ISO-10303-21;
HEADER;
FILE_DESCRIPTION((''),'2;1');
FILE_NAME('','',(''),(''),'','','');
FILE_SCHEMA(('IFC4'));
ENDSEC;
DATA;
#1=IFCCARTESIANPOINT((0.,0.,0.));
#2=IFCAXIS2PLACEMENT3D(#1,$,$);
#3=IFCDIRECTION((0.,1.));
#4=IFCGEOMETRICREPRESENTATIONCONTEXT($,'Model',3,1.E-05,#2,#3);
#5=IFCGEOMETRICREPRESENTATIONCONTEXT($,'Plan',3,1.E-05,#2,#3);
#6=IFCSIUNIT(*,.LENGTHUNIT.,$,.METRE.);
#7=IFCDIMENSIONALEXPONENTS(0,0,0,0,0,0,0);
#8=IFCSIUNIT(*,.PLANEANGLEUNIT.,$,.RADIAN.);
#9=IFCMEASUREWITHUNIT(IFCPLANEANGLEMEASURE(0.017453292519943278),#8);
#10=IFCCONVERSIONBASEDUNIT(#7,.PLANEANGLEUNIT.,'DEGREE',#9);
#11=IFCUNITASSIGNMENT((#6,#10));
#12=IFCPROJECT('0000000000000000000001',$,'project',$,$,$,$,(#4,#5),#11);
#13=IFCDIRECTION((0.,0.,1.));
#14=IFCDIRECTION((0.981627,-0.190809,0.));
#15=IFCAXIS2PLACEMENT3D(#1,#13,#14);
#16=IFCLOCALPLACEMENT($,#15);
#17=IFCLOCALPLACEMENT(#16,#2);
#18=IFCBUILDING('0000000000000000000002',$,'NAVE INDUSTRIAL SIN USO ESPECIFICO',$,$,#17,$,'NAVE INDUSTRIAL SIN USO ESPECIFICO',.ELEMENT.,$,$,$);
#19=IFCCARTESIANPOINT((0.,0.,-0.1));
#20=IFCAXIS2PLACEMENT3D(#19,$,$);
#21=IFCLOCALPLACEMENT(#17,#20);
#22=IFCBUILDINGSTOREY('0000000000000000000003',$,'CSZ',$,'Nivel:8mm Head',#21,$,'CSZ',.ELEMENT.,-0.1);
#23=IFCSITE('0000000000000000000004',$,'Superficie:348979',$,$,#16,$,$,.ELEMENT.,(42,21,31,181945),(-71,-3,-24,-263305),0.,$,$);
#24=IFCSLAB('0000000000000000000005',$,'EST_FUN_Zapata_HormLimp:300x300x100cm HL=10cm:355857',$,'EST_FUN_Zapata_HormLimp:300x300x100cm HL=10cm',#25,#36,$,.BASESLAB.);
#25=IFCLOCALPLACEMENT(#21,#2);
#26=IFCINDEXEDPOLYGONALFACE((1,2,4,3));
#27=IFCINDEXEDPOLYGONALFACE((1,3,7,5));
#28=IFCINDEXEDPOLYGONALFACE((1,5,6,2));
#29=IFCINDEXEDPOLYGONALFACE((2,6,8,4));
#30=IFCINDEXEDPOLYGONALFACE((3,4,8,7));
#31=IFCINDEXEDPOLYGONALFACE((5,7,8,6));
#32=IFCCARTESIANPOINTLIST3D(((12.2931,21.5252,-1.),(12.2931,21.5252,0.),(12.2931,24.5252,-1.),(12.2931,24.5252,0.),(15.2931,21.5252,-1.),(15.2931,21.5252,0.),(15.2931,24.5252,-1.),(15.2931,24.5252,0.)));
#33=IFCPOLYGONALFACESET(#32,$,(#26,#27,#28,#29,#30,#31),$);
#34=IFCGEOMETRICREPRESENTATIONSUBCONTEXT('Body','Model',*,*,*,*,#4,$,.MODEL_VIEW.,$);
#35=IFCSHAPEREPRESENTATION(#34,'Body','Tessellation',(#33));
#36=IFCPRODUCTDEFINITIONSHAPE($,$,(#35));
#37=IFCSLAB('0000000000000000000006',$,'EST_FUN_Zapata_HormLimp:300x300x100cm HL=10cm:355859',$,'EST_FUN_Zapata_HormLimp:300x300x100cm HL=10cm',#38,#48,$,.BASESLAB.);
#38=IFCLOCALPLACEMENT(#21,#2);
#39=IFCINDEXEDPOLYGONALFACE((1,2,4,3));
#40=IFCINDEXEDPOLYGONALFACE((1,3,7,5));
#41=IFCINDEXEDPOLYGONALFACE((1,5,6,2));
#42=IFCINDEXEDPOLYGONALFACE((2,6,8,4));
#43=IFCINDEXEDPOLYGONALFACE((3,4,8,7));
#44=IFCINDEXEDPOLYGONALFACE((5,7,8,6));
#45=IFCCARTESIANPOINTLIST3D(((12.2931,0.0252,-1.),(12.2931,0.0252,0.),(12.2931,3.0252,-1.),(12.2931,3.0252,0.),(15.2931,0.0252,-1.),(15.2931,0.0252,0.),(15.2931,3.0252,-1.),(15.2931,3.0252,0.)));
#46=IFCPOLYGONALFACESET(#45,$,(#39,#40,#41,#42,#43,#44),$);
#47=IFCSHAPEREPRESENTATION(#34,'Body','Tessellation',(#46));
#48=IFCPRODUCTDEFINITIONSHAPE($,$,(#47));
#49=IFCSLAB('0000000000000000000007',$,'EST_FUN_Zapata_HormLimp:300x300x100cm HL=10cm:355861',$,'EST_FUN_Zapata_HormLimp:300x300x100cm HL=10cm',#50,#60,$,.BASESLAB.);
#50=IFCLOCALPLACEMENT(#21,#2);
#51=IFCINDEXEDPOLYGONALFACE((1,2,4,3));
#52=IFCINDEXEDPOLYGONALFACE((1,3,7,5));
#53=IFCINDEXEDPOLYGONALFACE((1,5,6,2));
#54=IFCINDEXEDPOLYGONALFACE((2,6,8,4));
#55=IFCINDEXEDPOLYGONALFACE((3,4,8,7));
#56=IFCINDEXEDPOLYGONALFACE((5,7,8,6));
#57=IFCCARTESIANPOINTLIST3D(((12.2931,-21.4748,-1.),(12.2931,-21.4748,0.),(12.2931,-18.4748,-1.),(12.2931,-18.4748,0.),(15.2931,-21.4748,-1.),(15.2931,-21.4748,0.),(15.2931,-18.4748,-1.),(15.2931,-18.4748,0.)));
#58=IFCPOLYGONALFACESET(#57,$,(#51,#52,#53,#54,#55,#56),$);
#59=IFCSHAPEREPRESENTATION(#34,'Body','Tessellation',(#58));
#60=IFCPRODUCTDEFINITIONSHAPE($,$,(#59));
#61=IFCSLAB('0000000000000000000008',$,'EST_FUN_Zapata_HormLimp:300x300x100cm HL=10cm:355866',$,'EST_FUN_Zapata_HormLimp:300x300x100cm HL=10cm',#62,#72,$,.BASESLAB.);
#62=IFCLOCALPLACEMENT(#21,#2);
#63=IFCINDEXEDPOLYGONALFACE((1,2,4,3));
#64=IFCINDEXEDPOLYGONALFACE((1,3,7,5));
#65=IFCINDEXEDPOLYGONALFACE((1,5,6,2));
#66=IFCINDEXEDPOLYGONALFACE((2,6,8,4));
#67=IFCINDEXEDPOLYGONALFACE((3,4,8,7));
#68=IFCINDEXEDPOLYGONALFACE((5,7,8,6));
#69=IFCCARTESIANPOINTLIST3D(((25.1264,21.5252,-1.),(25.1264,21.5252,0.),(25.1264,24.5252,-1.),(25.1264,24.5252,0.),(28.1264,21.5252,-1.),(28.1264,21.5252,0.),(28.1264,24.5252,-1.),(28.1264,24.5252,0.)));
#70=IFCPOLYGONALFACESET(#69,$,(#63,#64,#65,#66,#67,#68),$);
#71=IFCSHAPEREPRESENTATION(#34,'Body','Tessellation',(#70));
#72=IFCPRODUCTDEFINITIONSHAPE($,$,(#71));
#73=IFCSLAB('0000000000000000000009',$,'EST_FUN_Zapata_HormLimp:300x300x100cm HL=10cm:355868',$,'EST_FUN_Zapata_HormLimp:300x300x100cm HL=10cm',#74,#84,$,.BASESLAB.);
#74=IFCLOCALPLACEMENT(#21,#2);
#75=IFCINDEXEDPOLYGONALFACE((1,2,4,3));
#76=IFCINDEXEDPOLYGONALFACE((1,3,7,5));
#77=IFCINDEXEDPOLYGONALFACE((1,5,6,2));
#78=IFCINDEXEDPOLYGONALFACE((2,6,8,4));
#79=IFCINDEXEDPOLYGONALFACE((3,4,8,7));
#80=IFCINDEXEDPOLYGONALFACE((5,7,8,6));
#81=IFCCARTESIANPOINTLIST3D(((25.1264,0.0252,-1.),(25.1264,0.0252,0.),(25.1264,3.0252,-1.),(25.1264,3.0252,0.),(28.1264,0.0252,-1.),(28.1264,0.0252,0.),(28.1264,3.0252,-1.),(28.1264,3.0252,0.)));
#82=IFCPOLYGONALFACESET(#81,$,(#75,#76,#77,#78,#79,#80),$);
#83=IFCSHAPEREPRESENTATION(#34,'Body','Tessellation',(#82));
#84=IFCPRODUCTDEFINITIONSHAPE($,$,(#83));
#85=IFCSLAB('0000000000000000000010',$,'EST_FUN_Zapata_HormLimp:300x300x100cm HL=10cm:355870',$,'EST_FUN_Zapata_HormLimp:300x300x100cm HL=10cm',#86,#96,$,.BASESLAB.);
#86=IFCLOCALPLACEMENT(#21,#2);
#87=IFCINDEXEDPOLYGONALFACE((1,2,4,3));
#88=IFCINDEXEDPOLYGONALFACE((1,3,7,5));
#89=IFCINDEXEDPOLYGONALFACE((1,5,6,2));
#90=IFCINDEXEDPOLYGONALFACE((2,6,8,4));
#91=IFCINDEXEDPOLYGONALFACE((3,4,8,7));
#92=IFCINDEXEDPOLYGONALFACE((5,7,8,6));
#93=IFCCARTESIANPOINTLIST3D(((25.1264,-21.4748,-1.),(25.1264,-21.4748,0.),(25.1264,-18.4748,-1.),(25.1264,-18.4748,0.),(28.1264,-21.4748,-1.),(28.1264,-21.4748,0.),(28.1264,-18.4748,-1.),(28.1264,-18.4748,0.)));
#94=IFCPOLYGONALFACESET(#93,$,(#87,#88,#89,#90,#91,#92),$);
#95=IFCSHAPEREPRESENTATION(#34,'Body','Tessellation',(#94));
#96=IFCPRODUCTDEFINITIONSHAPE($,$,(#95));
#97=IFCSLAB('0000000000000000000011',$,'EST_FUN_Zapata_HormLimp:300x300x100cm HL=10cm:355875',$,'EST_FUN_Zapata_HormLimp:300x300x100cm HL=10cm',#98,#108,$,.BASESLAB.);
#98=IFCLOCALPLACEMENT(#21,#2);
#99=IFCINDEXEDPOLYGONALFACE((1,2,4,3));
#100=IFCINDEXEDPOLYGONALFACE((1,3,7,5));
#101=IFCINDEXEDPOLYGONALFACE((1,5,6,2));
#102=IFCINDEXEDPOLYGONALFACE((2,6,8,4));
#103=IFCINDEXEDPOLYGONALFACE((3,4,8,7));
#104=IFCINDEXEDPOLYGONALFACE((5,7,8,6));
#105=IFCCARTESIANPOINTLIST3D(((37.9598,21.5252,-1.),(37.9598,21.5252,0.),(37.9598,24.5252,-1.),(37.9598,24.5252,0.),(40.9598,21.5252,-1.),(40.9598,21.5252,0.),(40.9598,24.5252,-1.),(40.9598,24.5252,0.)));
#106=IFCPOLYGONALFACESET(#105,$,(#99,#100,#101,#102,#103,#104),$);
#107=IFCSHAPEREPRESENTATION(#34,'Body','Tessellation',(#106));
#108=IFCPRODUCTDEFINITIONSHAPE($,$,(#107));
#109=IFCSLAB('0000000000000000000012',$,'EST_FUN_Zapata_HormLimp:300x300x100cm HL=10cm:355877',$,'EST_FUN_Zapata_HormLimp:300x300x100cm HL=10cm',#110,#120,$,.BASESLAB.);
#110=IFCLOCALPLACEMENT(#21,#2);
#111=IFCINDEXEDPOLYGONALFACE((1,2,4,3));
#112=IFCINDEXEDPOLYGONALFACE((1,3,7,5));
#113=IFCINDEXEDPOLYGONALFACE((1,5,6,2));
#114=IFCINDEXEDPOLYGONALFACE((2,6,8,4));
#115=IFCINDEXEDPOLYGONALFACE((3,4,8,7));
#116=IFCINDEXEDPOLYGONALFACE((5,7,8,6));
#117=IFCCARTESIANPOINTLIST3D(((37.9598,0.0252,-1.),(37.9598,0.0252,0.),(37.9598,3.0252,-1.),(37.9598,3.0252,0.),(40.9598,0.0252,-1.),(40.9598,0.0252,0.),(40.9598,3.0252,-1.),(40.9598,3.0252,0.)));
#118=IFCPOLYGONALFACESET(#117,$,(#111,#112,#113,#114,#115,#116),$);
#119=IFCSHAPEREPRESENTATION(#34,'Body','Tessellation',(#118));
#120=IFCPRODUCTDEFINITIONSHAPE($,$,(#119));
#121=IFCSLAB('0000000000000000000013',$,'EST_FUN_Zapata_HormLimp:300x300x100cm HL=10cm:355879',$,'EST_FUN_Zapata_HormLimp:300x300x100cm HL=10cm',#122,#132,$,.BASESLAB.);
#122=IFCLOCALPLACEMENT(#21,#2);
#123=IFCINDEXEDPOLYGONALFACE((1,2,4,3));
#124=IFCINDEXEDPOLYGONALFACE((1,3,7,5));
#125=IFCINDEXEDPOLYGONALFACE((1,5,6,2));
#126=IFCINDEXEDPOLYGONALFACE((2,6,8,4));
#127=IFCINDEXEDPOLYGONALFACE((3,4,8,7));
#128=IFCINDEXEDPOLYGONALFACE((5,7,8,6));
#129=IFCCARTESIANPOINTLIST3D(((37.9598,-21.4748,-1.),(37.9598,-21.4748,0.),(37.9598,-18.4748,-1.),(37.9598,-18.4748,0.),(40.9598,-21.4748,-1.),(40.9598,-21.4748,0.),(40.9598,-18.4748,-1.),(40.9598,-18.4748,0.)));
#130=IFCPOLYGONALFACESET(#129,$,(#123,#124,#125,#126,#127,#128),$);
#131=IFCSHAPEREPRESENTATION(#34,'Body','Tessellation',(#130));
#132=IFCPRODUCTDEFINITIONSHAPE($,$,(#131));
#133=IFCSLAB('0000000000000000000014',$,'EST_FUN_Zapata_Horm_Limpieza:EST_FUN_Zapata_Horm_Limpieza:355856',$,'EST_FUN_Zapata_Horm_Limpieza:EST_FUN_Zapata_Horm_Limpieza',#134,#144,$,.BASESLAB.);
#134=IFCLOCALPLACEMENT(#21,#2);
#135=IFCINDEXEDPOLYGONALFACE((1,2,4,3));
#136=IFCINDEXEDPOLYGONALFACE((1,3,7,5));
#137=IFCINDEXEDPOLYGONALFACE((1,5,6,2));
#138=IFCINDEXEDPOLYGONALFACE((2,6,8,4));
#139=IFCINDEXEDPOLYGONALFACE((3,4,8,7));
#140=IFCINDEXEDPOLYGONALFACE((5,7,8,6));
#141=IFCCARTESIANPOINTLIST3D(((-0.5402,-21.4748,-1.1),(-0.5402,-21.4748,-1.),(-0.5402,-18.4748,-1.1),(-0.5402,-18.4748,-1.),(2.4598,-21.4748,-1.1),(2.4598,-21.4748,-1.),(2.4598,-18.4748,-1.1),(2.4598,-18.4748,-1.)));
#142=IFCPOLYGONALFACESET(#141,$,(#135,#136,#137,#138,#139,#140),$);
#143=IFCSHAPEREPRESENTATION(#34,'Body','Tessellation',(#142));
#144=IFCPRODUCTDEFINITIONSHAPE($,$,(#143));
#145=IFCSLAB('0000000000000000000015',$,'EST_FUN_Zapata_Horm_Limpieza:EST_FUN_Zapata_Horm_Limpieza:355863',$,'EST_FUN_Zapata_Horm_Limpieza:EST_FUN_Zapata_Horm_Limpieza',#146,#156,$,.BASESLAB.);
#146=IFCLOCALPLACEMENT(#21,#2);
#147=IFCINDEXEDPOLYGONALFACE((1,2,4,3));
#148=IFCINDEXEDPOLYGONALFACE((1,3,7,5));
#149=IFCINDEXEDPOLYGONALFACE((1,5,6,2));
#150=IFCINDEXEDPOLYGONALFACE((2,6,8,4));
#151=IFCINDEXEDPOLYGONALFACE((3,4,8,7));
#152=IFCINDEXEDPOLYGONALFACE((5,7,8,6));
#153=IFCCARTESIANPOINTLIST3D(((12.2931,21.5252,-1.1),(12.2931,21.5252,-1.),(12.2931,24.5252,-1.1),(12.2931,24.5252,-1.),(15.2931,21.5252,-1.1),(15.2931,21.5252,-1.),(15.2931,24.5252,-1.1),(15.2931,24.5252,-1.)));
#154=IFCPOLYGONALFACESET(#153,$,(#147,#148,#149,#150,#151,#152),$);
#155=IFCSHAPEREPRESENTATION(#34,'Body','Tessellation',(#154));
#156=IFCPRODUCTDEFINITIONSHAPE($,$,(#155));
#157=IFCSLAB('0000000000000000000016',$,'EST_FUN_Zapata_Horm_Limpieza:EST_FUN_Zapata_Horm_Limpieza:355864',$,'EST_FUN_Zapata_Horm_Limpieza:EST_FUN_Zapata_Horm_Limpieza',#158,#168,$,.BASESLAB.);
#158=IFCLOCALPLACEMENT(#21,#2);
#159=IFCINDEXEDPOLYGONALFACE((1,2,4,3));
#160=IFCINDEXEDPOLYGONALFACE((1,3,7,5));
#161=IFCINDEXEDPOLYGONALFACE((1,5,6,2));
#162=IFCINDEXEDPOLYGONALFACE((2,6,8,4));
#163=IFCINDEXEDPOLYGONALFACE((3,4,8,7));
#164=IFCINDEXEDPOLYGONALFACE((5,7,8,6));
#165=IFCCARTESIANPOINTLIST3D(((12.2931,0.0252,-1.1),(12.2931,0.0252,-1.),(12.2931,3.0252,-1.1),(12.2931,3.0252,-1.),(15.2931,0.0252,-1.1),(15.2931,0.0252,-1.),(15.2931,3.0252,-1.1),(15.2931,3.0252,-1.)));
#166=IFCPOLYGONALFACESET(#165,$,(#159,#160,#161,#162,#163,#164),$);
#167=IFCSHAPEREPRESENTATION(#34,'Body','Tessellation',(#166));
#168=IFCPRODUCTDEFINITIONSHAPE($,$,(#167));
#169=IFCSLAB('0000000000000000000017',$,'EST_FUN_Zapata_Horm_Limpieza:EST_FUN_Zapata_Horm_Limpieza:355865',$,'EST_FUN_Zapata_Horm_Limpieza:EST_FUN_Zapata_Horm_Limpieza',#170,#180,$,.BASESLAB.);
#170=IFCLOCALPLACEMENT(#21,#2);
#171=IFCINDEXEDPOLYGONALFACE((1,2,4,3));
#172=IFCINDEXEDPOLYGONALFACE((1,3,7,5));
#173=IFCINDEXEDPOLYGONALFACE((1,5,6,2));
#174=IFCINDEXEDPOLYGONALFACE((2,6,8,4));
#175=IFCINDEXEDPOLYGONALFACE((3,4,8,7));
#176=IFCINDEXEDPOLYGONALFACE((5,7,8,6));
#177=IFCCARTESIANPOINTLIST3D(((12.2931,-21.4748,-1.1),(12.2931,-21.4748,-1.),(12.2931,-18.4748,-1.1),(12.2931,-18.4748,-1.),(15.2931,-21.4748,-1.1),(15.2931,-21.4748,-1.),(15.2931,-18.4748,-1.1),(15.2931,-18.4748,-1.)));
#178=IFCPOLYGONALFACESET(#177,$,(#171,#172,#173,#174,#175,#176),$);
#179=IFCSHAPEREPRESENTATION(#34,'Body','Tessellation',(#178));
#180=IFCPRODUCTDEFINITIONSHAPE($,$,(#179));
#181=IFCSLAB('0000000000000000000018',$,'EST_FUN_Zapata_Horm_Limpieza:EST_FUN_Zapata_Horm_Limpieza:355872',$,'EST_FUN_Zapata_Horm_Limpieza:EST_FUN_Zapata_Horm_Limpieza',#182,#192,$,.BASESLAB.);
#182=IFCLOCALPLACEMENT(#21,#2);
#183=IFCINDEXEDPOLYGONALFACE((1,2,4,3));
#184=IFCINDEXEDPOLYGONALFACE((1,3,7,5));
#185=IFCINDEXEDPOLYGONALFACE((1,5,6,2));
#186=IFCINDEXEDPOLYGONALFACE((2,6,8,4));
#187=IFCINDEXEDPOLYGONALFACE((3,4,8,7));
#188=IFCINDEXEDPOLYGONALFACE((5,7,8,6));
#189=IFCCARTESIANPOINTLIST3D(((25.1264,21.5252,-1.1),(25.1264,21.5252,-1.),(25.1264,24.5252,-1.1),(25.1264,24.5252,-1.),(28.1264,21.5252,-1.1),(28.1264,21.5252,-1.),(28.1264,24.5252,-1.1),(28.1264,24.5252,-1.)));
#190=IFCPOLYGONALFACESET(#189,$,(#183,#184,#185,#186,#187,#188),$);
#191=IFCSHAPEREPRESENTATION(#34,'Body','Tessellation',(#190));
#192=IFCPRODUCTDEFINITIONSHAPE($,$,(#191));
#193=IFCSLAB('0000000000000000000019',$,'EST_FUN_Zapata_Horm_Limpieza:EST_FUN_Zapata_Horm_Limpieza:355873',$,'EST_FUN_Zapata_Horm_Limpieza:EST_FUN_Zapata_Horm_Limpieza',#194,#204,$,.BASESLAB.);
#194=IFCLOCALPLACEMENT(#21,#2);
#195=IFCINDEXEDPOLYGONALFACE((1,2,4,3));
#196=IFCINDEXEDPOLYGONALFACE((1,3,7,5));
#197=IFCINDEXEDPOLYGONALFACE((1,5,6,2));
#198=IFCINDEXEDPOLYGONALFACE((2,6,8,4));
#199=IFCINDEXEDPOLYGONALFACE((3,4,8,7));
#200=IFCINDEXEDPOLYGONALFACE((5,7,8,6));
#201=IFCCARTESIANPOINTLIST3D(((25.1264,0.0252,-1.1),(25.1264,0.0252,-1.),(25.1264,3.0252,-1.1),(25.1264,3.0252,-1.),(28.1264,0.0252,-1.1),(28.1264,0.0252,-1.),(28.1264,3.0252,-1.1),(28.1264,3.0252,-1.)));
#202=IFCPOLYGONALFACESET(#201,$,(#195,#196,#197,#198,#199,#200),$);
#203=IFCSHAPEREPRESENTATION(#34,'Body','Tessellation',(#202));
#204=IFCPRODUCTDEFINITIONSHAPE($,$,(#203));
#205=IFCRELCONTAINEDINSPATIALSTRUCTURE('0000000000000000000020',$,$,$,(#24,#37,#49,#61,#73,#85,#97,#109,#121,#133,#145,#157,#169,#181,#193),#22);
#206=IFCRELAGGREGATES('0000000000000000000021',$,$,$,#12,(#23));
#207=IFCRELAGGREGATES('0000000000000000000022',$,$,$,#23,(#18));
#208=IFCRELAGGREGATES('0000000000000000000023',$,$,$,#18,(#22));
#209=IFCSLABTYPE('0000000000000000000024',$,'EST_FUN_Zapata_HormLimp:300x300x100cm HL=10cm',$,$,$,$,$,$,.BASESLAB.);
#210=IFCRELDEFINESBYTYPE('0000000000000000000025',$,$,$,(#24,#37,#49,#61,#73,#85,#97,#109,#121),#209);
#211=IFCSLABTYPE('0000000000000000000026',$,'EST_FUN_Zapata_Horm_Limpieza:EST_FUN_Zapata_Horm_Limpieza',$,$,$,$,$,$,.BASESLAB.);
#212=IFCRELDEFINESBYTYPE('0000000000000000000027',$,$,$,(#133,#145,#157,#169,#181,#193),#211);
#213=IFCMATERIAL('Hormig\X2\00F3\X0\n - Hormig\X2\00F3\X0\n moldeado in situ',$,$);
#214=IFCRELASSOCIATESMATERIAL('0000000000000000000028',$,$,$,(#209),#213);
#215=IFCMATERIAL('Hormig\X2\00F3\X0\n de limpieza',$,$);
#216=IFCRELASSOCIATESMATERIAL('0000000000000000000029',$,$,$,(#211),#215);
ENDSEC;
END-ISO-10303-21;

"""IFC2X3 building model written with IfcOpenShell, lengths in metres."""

from ifc_helpers import new_model, entity, si_unit, converted_unit, direction, frame, frame_2d, origin, origin_2d_with_axis, place, context, subcontext, project, spatial, rectangle, extrude, material, type_object, element, save


model = new_model("IFC2X3")

# Units and contexts
model_context = context("Model", 3, precision=1e-05, world=origin(), true_north=direction((0.0, 1.0)))
plan_context = context("Plan", 3, precision=1e-05, world=origin(), true_north=direction((0.0, 1.0)))
body_context = subcontext(model_context, "Body", "Model", "MODEL_VIEW")
ifc_project = project(units=[si_unit("LENGTHUNIT", "METRE"), converted_unit("PLANEANGLEUNIT", "DEGREE", entity("IfcPlaneAngleMeasure", 0.017453292519943278), si_unit("PLANEANGLEUNIT", "RADIAN"), dimensions=[0, 0, 0, 0, 0, 0, 0])], contexts=[model_context, plan_context])

# Site, building, storey
site_placement = place(None, frame((0.0, 0.0, 0.0), z_axis=(0.0, 0.0, 1.0), x_axis=(0.981627, -0.190809, 0.0)))
site = spatial("IfcSite", under=ifc_project, at=site_placement, Name="Superficie:348979", CompositionType="ELEMENT", RefLatitude=(42, 21, 31, 181945), RefLongitude=(-71, -3, -24, -263305), RefElevation=0.0)
building_placement = place(site_placement, origin())
building = spatial("IfcBuilding", under=site, at=building_placement, Name="NAVE INDUSTRIAL SIN USO ESPECIFICO", LongName="NAVE INDUSTRIAL SIN USO ESPECIFICO", CompositionType="ELEMENT")
storey_placement = place(building_placement, frame((0.0, 0.0, -0.1)))
storey = spatial("IfcBuildingStorey", under=building, at=storey_placement, Name="CSZ", ObjectType="Nivel:8mm Head", LongName="CSZ", CompositionType="ELEMENT", Elevation=-0.1)

# Slabs
ifc_material_1 = material(Name="Hormigón - Hormigón moldeado in situ")
slab_type_1 = type_object("IfcSlabType", Name="EST_FUN_Zapata_HormLimp:300x300x100cm HL=10cm", PredefinedType="BASESLAB", material=ifc_material_1)
slab_1_placement = place(storey_placement, origin())
element("IfcSlab", 1, at=slab_1_placement, inside=storey, type_object=slab_type_1, Name="EST_FUN_Zapata_HormLimp:300x300x100cm HL=10cm:355857", ObjectType="EST_FUN_Zapata_HormLimp:300x300x100cm HL=10cm", PredefinedType="BASESLAB", context=body_context, shape_type="SweptSolid", body=[
    extrude(rectangle(XDim=3.0, YDim=3.0, at=frame_2d((0.0, 0.0), x_axis=(1.0, 0.0))), frame((13.7931, 23.0252, -1.0)), (0.0, 0.0, 1.0), 1.0),
])
slab_2_placement = place(storey_placement, origin())
element("IfcSlab", 2, at=slab_2_placement, inside=storey, type_object=slab_type_1, Name="EST_FUN_Zapata_HormLimp:300x300x100cm HL=10cm:355859", ObjectType="EST_FUN_Zapata_HormLimp:300x300x100cm HL=10cm", PredefinedType="BASESLAB", context=body_context, shape_type="SweptSolid", body=[
    extrude(rectangle(XDim=3.0, YDim=3.0, at=frame_2d((0.0, 0.0), x_axis=(1.0, 0.0))), frame((13.7931, 1.5252, -1.0)), (0.0, 0.0, 1.0), 1.0),
])
slab_3_placement = place(storey_placement, origin())
element("IfcSlab", 3, at=slab_3_placement, inside=storey, type_object=slab_type_1, Name="EST_FUN_Zapata_HormLimp:300x300x100cm HL=10cm:355861", ObjectType="EST_FUN_Zapata_HormLimp:300x300x100cm HL=10cm", PredefinedType="BASESLAB", context=body_context, shape_type="SweptSolid", body=[
    extrude(rectangle(XDim=3.0, YDim=3.0, at=frame_2d((0.0, 0.0), x_axis=(1.0, 0.0))), frame((13.7931, -19.9748, -1.0)), (0.0, 0.0, 1.0), 1.0),
])
slab_4_placement = place(storey_placement, origin())
element("IfcSlab", 4, at=slab_4_placement, inside=storey, type_object=slab_type_1, Name="EST_FUN_Zapata_HormLimp:300x300x100cm HL=10cm:355866", ObjectType="EST_FUN_Zapata_HormLimp:300x300x100cm HL=10cm", PredefinedType="BASESLAB", context=body_context, shape_type="SweptSolid", body=[
    extrude(rectangle(XDim=3.0, YDim=3.0, at=frame_2d((0.0, 0.0), x_axis=(1.0, 0.0))), frame((26.6264, 23.0252, -1.0)), (0.0, 0.0, 1.0), 1.0),
])
slab_5_placement = place(storey_placement, origin())
element("IfcSlab", 5, at=slab_5_placement, inside=storey, type_object=slab_type_1, Name="EST_FUN_Zapata_HormLimp:300x300x100cm HL=10cm:355868", ObjectType="EST_FUN_Zapata_HormLimp:300x300x100cm HL=10cm", PredefinedType="BASESLAB", context=body_context, shape_type="SweptSolid", body=[
    extrude(rectangle(XDim=3.0, YDim=3.0, at=frame_2d((0.0, 0.0), x_axis=(1.0, 0.0))), frame((26.6264, 1.5252, -1.0)), (0.0, 0.0, 1.0), 1.0),
])
slab_6_placement = place(storey_placement, origin())
element("IfcSlab", 6, at=slab_6_placement, inside=storey, type_object=slab_type_1, Name="EST_FUN_Zapata_HormLimp:300x300x100cm HL=10cm:355870", ObjectType="EST_FUN_Zapata_HormLimp:300x300x100cm HL=10cm", PredefinedType="BASESLAB", context=body_context, shape_type="SweptSolid", body=[
    extrude(rectangle(XDim=3.0, YDim=3.0, at=frame_2d((0.0, 0.0), x_axis=(1.0, 0.0))), frame((26.6264, -19.9748, -1.0)), (0.0, 0.0, 1.0), 1.0),
])
slab_7_placement = place(storey_placement, origin())
element("IfcSlab", 7, at=slab_7_placement, inside=storey, type_object=slab_type_1, Name="EST_FUN_Zapata_HormLimp:300x300x100cm HL=10cm:355875", ObjectType="EST_FUN_Zapata_HormLimp:300x300x100cm HL=10cm", PredefinedType="BASESLAB", context=body_context, shape_type="SweptSolid", body=[
    extrude(rectangle(XDim=3.0, YDim=3.0, at=frame_2d((0.0, 0.0), x_axis=(1.0, 0.0))), frame((39.4598, 23.0252, -1.0)), (0.0, 0.0, 1.0), 1.0),
])
slab_8_placement = place(storey_placement, origin())
element("IfcSlab", 8, at=slab_8_placement, inside=storey, type_object=slab_type_1, Name="EST_FUN_Zapata_HormLimp:300x300x100cm HL=10cm:355877", ObjectType="EST_FUN_Zapata_HormLimp:300x300x100cm HL=10cm", PredefinedType="BASESLAB", context=body_context, shape_type="SweptSolid", body=[
    extrude(rectangle(XDim=3.0, YDim=3.0, at=frame_2d((0.0, 0.0), x_axis=(1.0, 0.0))), frame((39.4598, 1.5252, -1.0)), (0.0, 0.0, 1.0), 1.0),
])
slab_9_placement = place(storey_placement, origin())
element("IfcSlab", 9, at=slab_9_placement, inside=storey, type_object=slab_type_1, Name="EST_FUN_Zapata_HormLimp:300x300x100cm HL=10cm:355879", ObjectType="EST_FUN_Zapata_HormLimp:300x300x100cm HL=10cm", PredefinedType="BASESLAB", context=body_context, shape_type="SweptSolid", body=[
    extrude(rectangle(XDim=3.0, YDim=3.0, at=frame_2d((0.0, 0.0), x_axis=(1.0, 0.0))), frame((39.4598, -19.9748, -1.0)), (0.0, 0.0, 1.0), 1.0),
])
ifc_material_2 = material(Name="Hormigón de limpieza")
slab_type_2 = type_object("IfcSlabType", Name="EST_FUN_Zapata_Horm_Limpieza:EST_FUN_Zapata_Horm_Limpieza", PredefinedType="BASESLAB", material=ifc_material_2)
slab_10_placement = place(storey_placement, frame((0.0, 0.0, -1.0)))
element("IfcSlab", 10, at=slab_10_placement, inside=storey, type_object=slab_type_2, Name="EST_FUN_Zapata_Horm_Limpieza:EST_FUN_Zapata_Horm_Limpieza:355856", ObjectType="EST_FUN_Zapata_Horm_Limpieza:EST_FUN_Zapata_Horm_Limpieza", PredefinedType="BASESLAB", context=body_context, shape_type="SweptSolid", body=[
    extrude(rectangle(XDim=3.0, YDim=3.0, at=frame_2d((0.0, 0.0), x_axis=(1.0, 0.0))), frame((0.9598, -19.9748, -0.1)), (0.0, 0.0, 1.0), 0.1),
])
slab_11_placement = place(storey_placement, frame((0.0, 0.0, -1.0)))
element("IfcSlab", 11, at=slab_11_placement, inside=storey, type_object=slab_type_2, Name="EST_FUN_Zapata_Horm_Limpieza:EST_FUN_Zapata_Horm_Limpieza:355863", ObjectType="EST_FUN_Zapata_Horm_Limpieza:EST_FUN_Zapata_Horm_Limpieza", PredefinedType="BASESLAB", context=body_context, shape_type="SweptSolid", body=[
    extrude(rectangle(XDim=3.0, YDim=3.0, at=origin_2d_with_axis()), frame((13.7931, 23.0252, -0.1)), (0.0, 0.0, 1.0), 0.1),
])
slab_12_placement = place(storey_placement, frame((0.0, 0.0, -1.0)))
element("IfcSlab", 12, at=slab_12_placement, inside=storey, type_object=slab_type_2, Name="EST_FUN_Zapata_Horm_Limpieza:EST_FUN_Zapata_Horm_Limpieza:355864", ObjectType="EST_FUN_Zapata_Horm_Limpieza:EST_FUN_Zapata_Horm_Limpieza", PredefinedType="BASESLAB", context=body_context, shape_type="SweptSolid", body=[
    extrude(rectangle(XDim=3.0, YDim=3.0, at=frame_2d((0.0, 0.0), x_axis=(1.0, 0.0))), frame((13.7931, 1.5252, -0.1)), (0.0, 0.0, 1.0), 0.1),
])
slab_13_placement = place(storey_placement, frame((0.0, 0.0, -1.0)))
element("IfcSlab", 13, at=slab_13_placement, inside=storey, type_object=slab_type_2, Name="EST_FUN_Zapata_Horm_Limpieza:EST_FUN_Zapata_Horm_Limpieza:355865", ObjectType="EST_FUN_Zapata_Horm_Limpieza:EST_FUN_Zapata_Horm_Limpieza", PredefinedType="BASESLAB", context=body_context, shape_type="SweptSolid", body=[
    extrude(rectangle(XDim=3.0, YDim=3.0, at=frame_2d((0.0, 0.0), x_axis=(1.0, 0.0))), frame((13.7931, -19.9748, -0.1)), (0.0, 0.0, 1.0), 0.1),
])
slab_14_placement = place(storey_placement, frame((0.0, 0.0, -1.0)))
element("IfcSlab", 14, at=slab_14_placement, inside=storey, type_object=slab_type_2, Name="EST_FUN_Zapata_Horm_Limpieza:EST_FUN_Zapata_Horm_Limpieza:355872", ObjectType="EST_FUN_Zapata_Horm_Limpieza:EST_FUN_Zapata_Horm_Limpieza", PredefinedType="BASESLAB", context=body_context, shape_type="SweptSolid", body=[
    extrude(rectangle(XDim=3.0, YDim=3.0, at=frame_2d((0.0, 0.0), x_axis=(1.0, 0.0))), frame((26.6264, 23.0252, -0.1)), (0.0, 0.0, 1.0), 0.1),
])
slab_15_placement = place(storey_placement, frame((0.0, 0.0, -1.0)))
element("IfcSlab", 15, at=slab_15_placement, inside=storey, type_object=slab_type_2, Name="EST_FUN_Zapata_Horm_Limpieza:EST_FUN_Zapata_Horm_Limpieza:355873", ObjectType="EST_FUN_Zapata_Horm_Limpieza:EST_FUN_Zapata_Horm_Limpieza", PredefinedType="BASESLAB", context=body_context, shape_type="SweptSolid", body=[
    extrude(rectangle(XDim=3.0, YDim=3.0, at=frame_2d((0.0, 0.0), x_axis=(1.0, 0.0))), frame((26.6264, 1.5252, -0.1)), (0.0, 0.0, 1.0), 0.1),
])

save(model, "model.ifc")
